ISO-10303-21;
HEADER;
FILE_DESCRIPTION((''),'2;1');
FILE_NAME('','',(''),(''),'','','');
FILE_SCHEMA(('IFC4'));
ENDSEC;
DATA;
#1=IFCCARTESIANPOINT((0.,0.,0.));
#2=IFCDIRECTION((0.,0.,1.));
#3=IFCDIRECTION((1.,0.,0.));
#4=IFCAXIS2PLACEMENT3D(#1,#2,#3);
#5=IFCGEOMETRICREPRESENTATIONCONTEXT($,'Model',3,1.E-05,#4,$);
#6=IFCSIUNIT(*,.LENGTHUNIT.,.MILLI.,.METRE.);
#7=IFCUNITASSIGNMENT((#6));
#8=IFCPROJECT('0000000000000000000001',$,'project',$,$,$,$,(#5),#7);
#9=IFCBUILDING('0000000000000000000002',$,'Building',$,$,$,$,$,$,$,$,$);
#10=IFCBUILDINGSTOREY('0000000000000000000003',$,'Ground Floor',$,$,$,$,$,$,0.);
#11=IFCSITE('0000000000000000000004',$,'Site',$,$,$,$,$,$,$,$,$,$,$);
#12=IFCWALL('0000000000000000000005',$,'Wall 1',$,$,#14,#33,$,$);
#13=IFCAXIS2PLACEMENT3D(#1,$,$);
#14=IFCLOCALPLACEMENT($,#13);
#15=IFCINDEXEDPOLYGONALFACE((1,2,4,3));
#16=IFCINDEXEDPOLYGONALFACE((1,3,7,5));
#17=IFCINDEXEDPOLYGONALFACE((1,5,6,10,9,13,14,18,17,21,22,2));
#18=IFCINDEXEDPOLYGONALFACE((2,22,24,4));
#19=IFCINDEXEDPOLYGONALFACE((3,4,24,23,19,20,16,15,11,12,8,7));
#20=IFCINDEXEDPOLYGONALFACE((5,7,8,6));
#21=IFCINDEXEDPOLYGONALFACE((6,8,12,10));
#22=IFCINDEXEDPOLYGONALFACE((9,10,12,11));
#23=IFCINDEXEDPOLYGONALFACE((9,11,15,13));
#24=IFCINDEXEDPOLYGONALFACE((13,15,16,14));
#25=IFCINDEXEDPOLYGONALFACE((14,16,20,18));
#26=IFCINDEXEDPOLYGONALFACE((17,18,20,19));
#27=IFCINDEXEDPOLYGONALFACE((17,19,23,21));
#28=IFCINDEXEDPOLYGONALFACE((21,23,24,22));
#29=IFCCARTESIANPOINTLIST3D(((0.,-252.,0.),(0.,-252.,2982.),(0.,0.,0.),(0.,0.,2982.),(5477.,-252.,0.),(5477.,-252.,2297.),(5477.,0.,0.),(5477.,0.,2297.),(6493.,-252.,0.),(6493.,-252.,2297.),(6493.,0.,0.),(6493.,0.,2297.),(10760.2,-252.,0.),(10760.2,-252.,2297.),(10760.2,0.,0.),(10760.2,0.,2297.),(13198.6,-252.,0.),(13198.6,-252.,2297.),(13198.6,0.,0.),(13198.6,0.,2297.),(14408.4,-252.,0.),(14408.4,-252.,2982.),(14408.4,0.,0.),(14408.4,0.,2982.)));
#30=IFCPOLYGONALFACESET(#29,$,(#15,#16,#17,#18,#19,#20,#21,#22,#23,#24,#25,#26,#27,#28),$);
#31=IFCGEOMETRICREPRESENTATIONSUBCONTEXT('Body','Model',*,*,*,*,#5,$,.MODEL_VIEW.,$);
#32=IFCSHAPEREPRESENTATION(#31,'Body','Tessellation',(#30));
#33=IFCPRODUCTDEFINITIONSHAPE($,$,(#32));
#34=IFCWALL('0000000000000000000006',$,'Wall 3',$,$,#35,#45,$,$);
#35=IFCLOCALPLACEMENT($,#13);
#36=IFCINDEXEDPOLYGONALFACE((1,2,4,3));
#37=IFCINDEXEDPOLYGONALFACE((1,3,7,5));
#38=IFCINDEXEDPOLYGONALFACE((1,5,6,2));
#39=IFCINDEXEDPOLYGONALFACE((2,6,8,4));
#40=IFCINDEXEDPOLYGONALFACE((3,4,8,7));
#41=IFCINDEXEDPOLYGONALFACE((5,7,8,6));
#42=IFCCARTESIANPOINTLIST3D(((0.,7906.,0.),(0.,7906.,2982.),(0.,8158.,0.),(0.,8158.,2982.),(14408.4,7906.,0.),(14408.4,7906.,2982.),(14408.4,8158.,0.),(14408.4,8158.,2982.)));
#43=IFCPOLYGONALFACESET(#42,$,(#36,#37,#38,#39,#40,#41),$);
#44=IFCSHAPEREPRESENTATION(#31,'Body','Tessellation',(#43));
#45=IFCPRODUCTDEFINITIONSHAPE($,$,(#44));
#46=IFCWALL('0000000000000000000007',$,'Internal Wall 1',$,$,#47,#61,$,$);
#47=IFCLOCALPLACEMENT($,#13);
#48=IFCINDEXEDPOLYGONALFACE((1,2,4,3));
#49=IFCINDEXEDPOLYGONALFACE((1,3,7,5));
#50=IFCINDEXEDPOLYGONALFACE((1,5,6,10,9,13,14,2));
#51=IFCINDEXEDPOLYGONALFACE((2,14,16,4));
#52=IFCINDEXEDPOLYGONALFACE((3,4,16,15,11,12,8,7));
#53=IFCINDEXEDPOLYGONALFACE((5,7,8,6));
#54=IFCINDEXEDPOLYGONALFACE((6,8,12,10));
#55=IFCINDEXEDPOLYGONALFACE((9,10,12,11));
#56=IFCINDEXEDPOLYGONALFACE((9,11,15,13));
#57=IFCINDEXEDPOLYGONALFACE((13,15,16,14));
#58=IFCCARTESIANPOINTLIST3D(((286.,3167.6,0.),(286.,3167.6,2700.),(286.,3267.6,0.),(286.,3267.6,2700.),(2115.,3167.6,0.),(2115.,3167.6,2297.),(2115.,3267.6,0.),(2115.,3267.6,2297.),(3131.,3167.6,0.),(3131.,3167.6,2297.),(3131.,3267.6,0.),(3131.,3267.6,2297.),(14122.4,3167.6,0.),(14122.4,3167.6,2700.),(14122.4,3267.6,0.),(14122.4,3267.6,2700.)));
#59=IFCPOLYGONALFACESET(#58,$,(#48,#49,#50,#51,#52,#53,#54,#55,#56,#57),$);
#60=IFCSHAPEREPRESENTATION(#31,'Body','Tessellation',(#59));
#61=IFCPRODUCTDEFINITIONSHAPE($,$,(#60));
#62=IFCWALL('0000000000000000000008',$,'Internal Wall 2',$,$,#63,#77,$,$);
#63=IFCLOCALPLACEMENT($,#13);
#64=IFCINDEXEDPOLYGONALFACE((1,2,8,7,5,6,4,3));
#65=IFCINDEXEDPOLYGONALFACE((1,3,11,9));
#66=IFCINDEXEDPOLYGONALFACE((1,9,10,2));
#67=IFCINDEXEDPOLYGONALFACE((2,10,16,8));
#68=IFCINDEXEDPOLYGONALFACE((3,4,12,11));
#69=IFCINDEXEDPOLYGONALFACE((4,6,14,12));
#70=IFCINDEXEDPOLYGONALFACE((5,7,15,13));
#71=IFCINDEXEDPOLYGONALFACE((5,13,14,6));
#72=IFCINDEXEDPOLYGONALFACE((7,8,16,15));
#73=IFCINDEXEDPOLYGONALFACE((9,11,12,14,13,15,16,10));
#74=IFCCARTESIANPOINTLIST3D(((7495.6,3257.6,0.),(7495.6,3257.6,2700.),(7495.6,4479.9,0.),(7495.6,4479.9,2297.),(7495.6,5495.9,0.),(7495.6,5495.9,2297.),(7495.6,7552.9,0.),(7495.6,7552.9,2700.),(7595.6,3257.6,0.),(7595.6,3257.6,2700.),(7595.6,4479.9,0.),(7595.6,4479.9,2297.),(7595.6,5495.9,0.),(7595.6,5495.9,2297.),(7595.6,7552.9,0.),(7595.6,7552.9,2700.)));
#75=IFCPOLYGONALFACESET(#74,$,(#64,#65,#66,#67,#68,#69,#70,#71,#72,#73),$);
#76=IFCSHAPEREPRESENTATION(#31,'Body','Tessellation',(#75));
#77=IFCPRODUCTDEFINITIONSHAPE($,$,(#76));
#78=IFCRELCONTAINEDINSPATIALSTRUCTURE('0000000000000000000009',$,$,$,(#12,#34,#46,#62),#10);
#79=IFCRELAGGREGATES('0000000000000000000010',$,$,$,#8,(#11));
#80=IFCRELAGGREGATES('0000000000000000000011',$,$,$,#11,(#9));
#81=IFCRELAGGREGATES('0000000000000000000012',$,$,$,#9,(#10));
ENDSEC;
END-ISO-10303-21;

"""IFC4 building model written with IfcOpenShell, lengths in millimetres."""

from ifc_helpers import new_model, si_unit, frame, frame_2d, origin_with_axes, origin_2d, place, context, subcontext, project, spatial, rectangle, extrude, element, save


model = new_model("IFC4")

# Units and contexts
model_context = context("Model", 3, precision=1e-05, world=origin_with_axes())
body_context = subcontext(model_context, "Body", "Model", "MODEL_VIEW")
ifc_project = project(units=[si_unit("LENGTHUNIT", "METRE", prefix="MILLI")], contexts=[model_context])

# Site, building, storey
site = spatial("IfcSite", under=ifc_project, Name="Site")
building = spatial("IfcBuilding", under=site, Name="Building")
storey = spatial("IfcBuildingStorey", under=building, Name="Ground Floor", Elevation=0.0)

# Wall, openings
wall_1_placement = place(None, frame((0.0, -126.0, 0.0), z_axis=(0.0, 0.0, 1.0), x_axis=(1.0, 0.0, 0.0)))
wall_1 = element("IfcWall", 1, at=wall_1_placement, inside=storey, Name="Wall 1", context=body_context, shape_type="SweptSolid", body=[
    extrude(rectangle(XDim=14408.4, YDim=252.0, at=frame_2d((7204.2, 0.0))), None, (0.0, 0.0, 1.0), 2982.0),
])
opening_1_placement = place(wall_1_placement, frame((5985.0, 0.0, 0.0), z_axis=(0.0, 0.0, 1.0), x_axis=(1.0, 0.0, 0.0)))
element("IfcOpeningElement", 2, at=opening_1_placement, cuts=wall_1, context=body_context, shape_type="SweptSolid", body=[
    extrude(rectangle(XDim=1016.0, YDim=272.0, at=origin_2d()), None, (0.0, 0.0, 1.0), 2297.0),
])
opening_2_placement = place(wall_1_placement, frame((11979.4, 0.0, 0.0), z_axis=(0.0, 0.0, 1.0), x_axis=(1.0, 0.0, 0.0)))
element("IfcOpeningElement", 3, at=opening_2_placement, cuts=wall_1, context=body_context, shape_type="SweptSolid", body=[
    extrude(rectangle(XDim=2438.4, YDim=272.0, at=origin_2d()), None, (0.0, 0.0, 1.0), 2297.0),
])

# Wall
wall_2_placement = place(None, frame((14408.4, 8032.0, 0.0), z_axis=(0.0, 0.0, 1.0), x_axis=(-1.0, 0.0, 0.0)))
element("IfcWall", 4, at=wall_2_placement, inside=storey, Name="Wall 3", context=body_context, shape_type="SweptSolid", body=[
    extrude(rectangle(XDim=14408.4, YDim=252.0, at=frame_2d((7204.2, 0.0))), None, (0.0, 0.0, 1.0), 2982.0),
])

# Walls, openings
wall_3_placement = place(None, frame((286.0, 3217.6, 0.0), z_axis=(0.0, 0.0, 1.0), x_axis=(1.0, 0.0, 0.0)))
wall_3 = element("IfcWall", 5, at=wall_3_placement, inside=storey, Name="Internal Wall 1", context=body_context, shape_type="SweptSolid", body=[
    extrude(rectangle(XDim=13836.4, YDim=100.0, at=frame_2d((6918.2, 0.0))), None, (0.0, 0.0, 1.0), 2700.0),
])
opening_3_placement = place(wall_3_placement, frame((2337.0, 0.0, 0.0), z_axis=(0.0, 0.0, 1.0), x_axis=(1.0, 0.0, 0.0)))
element("IfcOpeningElement", 6, at=opening_3_placement, cuts=wall_3, context=body_context, shape_type="SweptSolid", body=[
    extrude(rectangle(XDim=1016.0, YDim=120.0, at=origin_2d()), None, (0.0, 0.0, 1.0), 2297.0),
])
wall_4_placement = place(None, frame((7545.6, 7552.9, 0.0), z_axis=(0.0, 0.0, 1.0), x_axis=(0.0, -1.0, 0.0)))
wall_4 = element("IfcWall", 7, at=wall_4_placement, inside=storey, Name="Internal Wall 2", context=body_context, shape_type="SweptSolid", body=[
    extrude(rectangle(XDim=4295.3, YDim=100.0, at=frame_2d((2147.7, 0.0))), None, (0.0, 0.0, 1.0), 2700.0),
])
opening_4_placement = place(wall_4_placement, frame((2565.0, 0.0, 0.0), z_axis=(0.0, 0.0, 1.0), x_axis=(1.0, 0.0, 0.0)))
element("IfcOpeningElement", 8, at=opening_4_placement, cuts=wall_4, context=body_context, shape_type="SweptSolid", body=[
    extrude(rectangle(XDim=1016.0, YDim=120.0, at=origin_2d()), None, (0.0, 0.0, 1.0), 2297.0),
])

save(model, "model.ifc")
